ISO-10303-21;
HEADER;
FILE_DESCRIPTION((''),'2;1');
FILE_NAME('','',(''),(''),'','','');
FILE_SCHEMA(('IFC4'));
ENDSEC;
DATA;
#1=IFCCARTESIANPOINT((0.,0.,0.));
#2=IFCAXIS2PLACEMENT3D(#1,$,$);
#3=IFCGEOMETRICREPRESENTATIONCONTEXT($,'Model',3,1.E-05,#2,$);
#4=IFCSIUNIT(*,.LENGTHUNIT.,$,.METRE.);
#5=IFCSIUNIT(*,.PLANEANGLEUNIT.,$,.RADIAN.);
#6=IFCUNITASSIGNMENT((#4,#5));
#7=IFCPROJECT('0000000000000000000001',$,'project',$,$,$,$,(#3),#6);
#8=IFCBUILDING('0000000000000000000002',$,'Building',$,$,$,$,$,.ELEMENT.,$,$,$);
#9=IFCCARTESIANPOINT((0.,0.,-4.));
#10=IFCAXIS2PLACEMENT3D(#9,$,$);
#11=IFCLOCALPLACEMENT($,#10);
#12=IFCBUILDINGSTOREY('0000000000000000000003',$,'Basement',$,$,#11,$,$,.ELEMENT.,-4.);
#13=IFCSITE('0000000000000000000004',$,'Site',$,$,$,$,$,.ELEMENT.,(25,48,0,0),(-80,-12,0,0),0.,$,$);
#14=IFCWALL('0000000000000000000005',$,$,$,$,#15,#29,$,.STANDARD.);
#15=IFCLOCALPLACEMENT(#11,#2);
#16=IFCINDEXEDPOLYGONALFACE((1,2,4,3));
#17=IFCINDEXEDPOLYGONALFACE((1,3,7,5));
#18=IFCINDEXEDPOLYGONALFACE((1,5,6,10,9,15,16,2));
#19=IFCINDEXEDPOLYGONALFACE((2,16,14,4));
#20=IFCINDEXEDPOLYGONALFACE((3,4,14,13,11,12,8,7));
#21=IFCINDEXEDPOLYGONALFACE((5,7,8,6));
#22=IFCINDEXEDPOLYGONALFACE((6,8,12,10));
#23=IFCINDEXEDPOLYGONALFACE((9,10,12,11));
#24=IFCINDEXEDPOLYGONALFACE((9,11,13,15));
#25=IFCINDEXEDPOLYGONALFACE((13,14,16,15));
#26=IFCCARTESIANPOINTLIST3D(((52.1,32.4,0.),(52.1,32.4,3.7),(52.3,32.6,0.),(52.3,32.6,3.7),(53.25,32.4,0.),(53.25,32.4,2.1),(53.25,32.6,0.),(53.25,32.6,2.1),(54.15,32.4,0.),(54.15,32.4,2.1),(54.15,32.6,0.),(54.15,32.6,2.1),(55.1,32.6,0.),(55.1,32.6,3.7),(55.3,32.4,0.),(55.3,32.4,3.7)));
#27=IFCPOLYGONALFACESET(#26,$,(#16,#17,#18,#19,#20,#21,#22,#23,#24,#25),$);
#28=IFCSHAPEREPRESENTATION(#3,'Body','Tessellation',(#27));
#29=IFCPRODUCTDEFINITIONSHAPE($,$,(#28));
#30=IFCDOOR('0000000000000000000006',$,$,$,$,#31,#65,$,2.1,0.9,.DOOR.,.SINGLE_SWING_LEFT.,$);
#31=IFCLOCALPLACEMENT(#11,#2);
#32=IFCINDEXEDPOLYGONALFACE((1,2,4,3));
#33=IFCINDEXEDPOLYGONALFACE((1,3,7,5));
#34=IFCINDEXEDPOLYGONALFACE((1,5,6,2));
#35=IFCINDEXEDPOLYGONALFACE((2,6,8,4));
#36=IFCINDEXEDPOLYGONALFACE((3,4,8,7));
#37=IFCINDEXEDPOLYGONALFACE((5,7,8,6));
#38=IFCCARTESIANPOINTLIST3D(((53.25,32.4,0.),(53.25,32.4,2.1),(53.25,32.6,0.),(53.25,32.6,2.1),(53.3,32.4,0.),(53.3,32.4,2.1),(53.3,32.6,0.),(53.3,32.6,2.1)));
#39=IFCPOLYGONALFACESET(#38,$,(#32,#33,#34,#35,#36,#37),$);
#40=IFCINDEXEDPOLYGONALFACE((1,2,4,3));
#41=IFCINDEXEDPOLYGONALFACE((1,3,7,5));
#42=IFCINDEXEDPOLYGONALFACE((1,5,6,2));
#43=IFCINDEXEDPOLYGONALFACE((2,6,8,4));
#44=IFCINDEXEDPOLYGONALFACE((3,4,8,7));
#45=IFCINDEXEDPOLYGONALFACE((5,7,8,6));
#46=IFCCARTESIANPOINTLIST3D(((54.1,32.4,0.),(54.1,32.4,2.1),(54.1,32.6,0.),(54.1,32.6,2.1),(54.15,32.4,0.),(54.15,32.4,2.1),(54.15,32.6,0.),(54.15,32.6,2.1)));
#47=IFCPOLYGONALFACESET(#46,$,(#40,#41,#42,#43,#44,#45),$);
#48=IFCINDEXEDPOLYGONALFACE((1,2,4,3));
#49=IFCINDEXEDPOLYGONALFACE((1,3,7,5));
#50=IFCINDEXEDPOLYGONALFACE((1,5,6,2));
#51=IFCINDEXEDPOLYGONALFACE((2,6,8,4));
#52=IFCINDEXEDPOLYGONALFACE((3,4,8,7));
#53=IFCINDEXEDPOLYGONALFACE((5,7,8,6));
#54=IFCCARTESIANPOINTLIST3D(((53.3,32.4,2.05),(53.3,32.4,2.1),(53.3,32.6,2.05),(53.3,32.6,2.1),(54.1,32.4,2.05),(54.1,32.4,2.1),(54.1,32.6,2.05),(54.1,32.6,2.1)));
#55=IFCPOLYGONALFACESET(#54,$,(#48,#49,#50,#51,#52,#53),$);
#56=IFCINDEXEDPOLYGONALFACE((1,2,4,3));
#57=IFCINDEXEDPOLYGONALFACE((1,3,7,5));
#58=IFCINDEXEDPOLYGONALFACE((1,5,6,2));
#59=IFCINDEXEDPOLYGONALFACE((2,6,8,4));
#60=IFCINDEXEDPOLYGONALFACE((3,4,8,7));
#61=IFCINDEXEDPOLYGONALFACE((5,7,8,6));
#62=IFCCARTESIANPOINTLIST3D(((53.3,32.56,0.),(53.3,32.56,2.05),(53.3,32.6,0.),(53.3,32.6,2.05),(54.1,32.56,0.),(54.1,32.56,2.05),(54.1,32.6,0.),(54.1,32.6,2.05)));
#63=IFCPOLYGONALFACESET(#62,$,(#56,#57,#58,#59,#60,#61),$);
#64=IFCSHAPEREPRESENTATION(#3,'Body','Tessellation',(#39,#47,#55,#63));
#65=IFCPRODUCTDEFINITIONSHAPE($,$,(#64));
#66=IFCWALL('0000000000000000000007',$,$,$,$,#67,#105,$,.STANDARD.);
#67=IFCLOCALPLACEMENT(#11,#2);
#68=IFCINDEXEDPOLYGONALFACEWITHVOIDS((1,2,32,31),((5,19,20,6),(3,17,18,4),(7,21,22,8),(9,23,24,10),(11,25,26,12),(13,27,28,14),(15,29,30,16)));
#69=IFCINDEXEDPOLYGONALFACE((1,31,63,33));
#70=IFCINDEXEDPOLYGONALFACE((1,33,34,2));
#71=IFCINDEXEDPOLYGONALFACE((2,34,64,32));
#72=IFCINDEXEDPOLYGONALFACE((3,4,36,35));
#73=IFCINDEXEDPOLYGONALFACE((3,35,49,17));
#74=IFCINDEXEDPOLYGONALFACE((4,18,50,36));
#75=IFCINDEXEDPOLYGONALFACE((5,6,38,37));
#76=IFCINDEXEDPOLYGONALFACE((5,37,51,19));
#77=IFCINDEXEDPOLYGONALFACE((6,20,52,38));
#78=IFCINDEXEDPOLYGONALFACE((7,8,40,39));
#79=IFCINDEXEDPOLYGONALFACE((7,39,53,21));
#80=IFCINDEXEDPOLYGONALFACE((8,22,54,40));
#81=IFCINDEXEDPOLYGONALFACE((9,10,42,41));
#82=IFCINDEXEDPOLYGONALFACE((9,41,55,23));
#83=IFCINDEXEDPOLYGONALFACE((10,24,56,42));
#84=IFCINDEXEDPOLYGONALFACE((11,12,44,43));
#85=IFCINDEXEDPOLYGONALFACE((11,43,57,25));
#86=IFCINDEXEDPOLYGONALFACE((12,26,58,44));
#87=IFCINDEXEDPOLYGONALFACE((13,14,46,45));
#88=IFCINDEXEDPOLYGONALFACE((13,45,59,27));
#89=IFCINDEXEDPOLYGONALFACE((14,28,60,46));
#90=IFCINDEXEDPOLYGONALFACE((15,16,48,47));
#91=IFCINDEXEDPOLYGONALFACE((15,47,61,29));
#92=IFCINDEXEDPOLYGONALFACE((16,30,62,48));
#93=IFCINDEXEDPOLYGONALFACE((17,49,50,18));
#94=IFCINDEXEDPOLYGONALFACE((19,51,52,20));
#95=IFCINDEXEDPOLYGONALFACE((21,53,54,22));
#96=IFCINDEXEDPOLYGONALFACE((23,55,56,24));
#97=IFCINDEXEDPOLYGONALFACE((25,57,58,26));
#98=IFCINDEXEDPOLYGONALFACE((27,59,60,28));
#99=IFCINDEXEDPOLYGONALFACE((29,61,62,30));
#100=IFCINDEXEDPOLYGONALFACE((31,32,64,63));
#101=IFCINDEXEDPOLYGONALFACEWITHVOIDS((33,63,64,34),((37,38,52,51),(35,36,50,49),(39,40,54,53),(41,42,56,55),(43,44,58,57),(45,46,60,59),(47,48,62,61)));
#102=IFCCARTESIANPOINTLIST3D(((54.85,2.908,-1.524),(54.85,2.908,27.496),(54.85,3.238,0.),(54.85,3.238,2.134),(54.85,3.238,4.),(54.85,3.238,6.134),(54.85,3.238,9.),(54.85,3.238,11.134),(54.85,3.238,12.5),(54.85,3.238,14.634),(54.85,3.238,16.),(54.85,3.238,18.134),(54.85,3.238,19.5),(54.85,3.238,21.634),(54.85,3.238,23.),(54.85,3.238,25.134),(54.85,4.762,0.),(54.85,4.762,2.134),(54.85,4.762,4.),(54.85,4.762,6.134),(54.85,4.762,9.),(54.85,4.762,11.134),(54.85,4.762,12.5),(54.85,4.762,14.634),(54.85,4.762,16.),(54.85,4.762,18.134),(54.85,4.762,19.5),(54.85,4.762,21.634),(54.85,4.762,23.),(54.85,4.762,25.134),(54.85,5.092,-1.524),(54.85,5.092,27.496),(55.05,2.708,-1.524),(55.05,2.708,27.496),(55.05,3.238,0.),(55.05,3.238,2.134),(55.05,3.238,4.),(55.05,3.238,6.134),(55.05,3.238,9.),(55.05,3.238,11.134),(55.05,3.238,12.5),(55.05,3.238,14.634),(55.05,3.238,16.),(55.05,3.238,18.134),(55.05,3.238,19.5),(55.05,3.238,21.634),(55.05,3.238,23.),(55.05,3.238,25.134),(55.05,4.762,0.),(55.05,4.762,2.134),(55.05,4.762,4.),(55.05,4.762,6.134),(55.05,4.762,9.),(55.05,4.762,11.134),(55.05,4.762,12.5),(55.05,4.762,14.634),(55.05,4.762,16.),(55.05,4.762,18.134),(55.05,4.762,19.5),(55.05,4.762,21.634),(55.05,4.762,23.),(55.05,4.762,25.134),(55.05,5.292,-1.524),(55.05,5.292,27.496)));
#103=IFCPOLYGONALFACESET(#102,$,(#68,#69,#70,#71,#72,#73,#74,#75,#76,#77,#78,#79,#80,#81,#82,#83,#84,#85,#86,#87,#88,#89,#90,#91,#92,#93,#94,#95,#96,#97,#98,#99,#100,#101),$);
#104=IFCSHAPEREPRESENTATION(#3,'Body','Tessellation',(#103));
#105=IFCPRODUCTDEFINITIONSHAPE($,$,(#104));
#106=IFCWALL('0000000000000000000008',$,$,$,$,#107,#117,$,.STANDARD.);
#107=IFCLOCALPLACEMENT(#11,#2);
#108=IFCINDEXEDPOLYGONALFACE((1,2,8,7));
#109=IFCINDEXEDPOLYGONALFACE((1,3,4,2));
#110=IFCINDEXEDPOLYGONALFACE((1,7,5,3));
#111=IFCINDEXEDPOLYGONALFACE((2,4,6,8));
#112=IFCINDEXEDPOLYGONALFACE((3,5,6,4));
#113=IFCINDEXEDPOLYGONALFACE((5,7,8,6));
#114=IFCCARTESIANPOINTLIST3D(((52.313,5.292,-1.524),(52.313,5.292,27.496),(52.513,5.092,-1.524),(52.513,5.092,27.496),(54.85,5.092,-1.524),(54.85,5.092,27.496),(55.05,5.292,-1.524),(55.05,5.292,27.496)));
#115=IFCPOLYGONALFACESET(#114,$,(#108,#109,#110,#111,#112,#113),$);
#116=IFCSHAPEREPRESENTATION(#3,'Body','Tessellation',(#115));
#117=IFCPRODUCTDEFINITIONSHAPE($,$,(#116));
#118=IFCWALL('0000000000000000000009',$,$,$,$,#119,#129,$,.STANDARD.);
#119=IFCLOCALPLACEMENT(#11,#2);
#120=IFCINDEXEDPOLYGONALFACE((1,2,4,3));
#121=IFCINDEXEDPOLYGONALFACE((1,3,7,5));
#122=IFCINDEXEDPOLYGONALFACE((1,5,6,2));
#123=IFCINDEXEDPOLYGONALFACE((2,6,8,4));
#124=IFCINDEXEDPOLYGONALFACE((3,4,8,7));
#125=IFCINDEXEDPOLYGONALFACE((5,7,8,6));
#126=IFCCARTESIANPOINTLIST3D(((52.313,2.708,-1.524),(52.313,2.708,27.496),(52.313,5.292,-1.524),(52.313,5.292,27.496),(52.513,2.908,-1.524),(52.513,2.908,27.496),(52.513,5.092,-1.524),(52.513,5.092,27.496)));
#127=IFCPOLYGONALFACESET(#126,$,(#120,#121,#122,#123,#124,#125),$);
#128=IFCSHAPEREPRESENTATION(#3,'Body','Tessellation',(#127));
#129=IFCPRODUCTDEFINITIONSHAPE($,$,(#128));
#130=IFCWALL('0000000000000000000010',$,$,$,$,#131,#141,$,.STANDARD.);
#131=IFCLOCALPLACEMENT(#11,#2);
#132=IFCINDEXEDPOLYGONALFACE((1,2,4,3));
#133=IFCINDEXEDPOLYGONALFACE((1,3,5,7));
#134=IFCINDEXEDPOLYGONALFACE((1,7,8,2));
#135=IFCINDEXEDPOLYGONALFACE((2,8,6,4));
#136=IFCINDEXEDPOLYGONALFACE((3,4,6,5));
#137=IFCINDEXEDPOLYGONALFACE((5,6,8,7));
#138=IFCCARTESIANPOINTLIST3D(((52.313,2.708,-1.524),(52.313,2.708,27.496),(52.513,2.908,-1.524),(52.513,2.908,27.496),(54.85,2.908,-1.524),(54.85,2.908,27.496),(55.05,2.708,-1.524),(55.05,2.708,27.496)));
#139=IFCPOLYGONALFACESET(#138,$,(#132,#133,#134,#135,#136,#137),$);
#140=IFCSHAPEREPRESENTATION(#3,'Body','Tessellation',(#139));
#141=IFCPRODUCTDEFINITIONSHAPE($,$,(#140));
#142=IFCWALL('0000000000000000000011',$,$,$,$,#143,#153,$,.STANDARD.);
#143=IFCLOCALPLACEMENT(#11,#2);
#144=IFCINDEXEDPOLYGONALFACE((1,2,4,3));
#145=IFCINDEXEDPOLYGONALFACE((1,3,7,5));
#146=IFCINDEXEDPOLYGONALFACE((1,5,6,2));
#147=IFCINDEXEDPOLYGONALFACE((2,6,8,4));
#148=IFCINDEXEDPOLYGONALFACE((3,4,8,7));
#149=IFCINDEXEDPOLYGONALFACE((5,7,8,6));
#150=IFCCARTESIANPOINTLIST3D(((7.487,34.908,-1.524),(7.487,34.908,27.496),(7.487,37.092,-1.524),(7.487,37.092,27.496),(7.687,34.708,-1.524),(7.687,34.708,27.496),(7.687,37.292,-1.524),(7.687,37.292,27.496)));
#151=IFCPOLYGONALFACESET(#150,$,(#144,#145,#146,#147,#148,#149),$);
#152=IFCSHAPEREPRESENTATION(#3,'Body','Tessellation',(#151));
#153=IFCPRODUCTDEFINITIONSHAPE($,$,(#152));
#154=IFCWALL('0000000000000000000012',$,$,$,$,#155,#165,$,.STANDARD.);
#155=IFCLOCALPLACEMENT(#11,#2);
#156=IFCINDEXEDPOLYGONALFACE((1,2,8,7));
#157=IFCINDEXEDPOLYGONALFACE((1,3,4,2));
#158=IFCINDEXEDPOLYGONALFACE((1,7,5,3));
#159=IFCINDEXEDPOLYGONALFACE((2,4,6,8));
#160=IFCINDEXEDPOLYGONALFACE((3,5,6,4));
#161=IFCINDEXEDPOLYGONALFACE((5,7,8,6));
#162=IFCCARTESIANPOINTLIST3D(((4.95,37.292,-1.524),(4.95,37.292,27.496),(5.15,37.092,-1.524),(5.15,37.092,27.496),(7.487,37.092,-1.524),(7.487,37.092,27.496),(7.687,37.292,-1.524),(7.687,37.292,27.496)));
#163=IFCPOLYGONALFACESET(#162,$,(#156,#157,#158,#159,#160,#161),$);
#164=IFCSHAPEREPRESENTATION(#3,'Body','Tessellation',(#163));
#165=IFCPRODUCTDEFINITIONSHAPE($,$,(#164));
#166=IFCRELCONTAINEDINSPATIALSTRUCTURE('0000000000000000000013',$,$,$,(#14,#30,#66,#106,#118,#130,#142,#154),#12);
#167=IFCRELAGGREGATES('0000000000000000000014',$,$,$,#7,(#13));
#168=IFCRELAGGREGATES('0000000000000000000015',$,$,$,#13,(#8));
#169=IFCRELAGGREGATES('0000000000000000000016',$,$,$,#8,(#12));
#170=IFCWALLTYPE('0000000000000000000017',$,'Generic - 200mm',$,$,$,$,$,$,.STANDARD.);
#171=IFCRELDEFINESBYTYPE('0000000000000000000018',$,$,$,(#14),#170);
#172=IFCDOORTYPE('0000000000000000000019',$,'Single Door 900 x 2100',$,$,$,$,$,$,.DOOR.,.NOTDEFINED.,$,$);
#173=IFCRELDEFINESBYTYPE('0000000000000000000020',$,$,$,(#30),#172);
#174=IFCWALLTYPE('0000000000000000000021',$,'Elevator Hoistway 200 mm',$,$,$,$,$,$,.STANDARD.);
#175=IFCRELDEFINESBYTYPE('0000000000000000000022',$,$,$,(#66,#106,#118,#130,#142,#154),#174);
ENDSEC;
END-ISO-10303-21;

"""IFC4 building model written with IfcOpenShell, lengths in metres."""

from ifc_helpers import new_model, si_unit, frame, frame_2d, origin, origin_with_axes, origin_2d, place, context, project, spatial, polyline, rectangle, outline, extrude, type_object, element, fill, save


model = new_model("IFC4")

# Units and contexts
model_context = context("Model", 3, precision=1e-05, world=origin())
ifc_project = project(units=[si_unit("LENGTHUNIT", "METRE"), si_unit("PLANEANGLEUNIT", "RADIAN")], contexts=[model_context])

# Site, building, storey
site = spatial("IfcSite", under=ifc_project, Name="Site", CompositionType="ELEMENT", RefLatitude=(25, 48, 0, 0), RefLongitude=(-80, -12, 0, 0), RefElevation=0.0)
building = spatial("IfcBuilding", under=site, Name="Building", CompositionType="ELEMENT")
storey_placement = place(None, frame((0.0, 0.0, -4.0)))
storey = spatial("IfcBuildingStorey", under=building, at=storey_placement, Name="Basement", CompositionType="ELEMENT", Elevation=-4.0)

# Shared definitions
wall_type_1 = type_object("IfcWallType", Name="Generic - 200mm", PredefinedType="STANDARD")
door_type = type_object("IfcDoorType", Name="Single Door 900 x 2100", OperationType="NOTDEFINED", PredefinedType="DOOR")

# Wall, opening, door
wall_1_placement = place(None, frame((52.2, 32.5, -4.0), z_axis=(0.0, 0.0, 1.0), x_axis=(1.0, 0.0, 0.0)))
wall_1 = element("IfcWall", 1, at=wall_1_placement, inside=storey, type_object=wall_type_1, PredefinedType="STANDARD", context=model_context, shape_type="SweptSolid", body=[
    extrude(outline(polyline([(-0.1, -0.1), (3.1, -0.1), (2.9, 0.1), (0.1, 0.1), (-0.1, -0.1)])), origin(), (0.0, 0.0, 1.0), 3.7),
])
opening_1_placement = place(wall_1_placement, frame((1.5, 0.0, 0.0), z_axis=(0.0, 0.0, 1.0), x_axis=(1.0, 0.0, 0.0)))
opening_1 = element("IfcOpeningElement", 2, at=opening_1_placement, cuts=wall_1, PredefinedType="OPENING", context=model_context, shape_type="SweptSolid", body=[
    extrude(rectangle(XDim=0.9, YDim=0.202, at=origin_2d()), origin(), (0.0, 0.0, 1.0), 2.1),
])
door_1_placement = place(opening_1_placement, origin_with_axes())
door_1 = element("IfcDoor", 3, at=door_1_placement, inside=storey, type_object=door_type, OperationType="SINGLE_SWING_LEFT", OverallHeight=2.1, OverallWidth=0.9, PredefinedType="DOOR", context=model_context, shape_type="SweptSolid", body=[
    extrude(rectangle(XDim=0.05, YDim=0.2, at=frame_2d((-0.425, 0.0))), origin(), (0.0, 0.0, 1.0), 2.1),
    extrude(rectangle(XDim=0.05, YDim=0.2, at=frame_2d((0.425, 0.0))), origin(), (0.0, 0.0, 1.0), 2.1),
    extrude(rectangle(XDim=0.8, YDim=0.2, at=origin_2d()), frame((0.0, 0.0, 2.05)), (0.0, 0.0, 1.0), 0.05),
    extrude(rectangle(XDim=0.8, YDim=0.04, at=frame_2d((0.0, 0.08))), origin(), (0.0, 0.0, 1.0), 2.05),
])
fill(opening_1, door_1)

# Wall, openings
wall_type_2 = type_object("IfcWallType", Name="Elevator Hoistway 200 mm", PredefinedType="STANDARD")
wall_2_placement = place(None, frame((54.95, 2.808, -5.524), z_axis=(0.0, 0.0, 1.0), x_axis=(0.0, 1.0, 0.0)))
wall_2 = element("IfcWall", 4, at=wall_2_placement, inside=storey, type_object=wall_type_2, PredefinedType="STANDARD", context=model_context, shape_type="SweptSolid", body=[
    extrude(outline(polyline([(-0.1, -0.1), (2.484, -0.1), (2.284, 0.1), (0.1, 0.1), (-0.1, -0.1)])), origin(), (0.0, 0.0, 1.0), 29.02),
])
opening_2_placement = place(wall_2_placement, frame((1.192, 0.0, 1.524), z_axis=(0.0, 0.0, 1.0), x_axis=(1.0, 0.0, 0.0)))
element("IfcOpeningElement", 5, at=opening_2_placement, cuts=wall_2, PredefinedType="OPENING", context=model_context, shape_type="SweptSolid", body=[
    extrude(rectangle(XDim=1.524, YDim=0.202, at=origin_2d()), origin(), (0.0, 0.0, 1.0), 2.134),
])
opening_3_placement = place(wall_2_placement, frame((1.192, 0.0, 5.524), z_axis=(0.0, 0.0, 1.0), x_axis=(1.0, 0.0, 0.0)))
element("IfcOpeningElement", 6, at=opening_3_placement, cuts=wall_2, PredefinedType="OPENING", context=model_context, shape_type="SweptSolid", body=[
    extrude(rectangle(XDim=1.524, YDim=0.202, at=origin_2d()), origin(), (0.0, 0.0, 1.0), 2.134),
])
opening_4_placement = place(wall_2_placement, frame((1.192, 0.0, 10.524), z_axis=(0.0, 0.0, 1.0), x_axis=(1.0, 0.0, 0.0)))
element("IfcOpeningElement", 7, at=opening_4_placement, cuts=wall_2, PredefinedType="OPENING", context=model_context, shape_type="SweptSolid", body=[
    extrude(rectangle(XDim=1.524, YDim=0.202, at=origin_2d()), origin(), (0.0, 0.0, 1.0), 2.134),
])
opening_5_placement = place(wall_2_placement, frame((1.192, 0.0, 14.024), z_axis=(0.0, 0.0, 1.0), x_axis=(1.0, 0.0, 0.0)))
element("IfcOpeningElement", 8, at=opening_5_placement, cuts=wall_2, PredefinedType="OPENING", context=model_context, shape_type="SweptSolid", body=[
    extrude(rectangle(XDim=1.524, YDim=0.202, at=origin_2d()), origin(), (0.0, 0.0, 1.0), 2.134),
])
opening_6_placement = place(wall_2_placement, frame((1.192, 0.0, 17.524), z_axis=(0.0, 0.0, 1.0), x_axis=(1.0, 0.0, 0.0)))
element("IfcOpeningElement", 9, at=opening_6_placement, cuts=wall_2, PredefinedType="OPENING", context=model_context, shape_type="SweptSolid", body=[
    extrude(rectangle(XDim=1.524, YDim=0.202, at=origin_2d()), origin(), (0.0, 0.0, 1.0), 2.134),
])
opening_7_placement = place(wall_2_placement, frame((1.192, 0.0, 21.024), z_axis=(0.0, 0.0, 1.0), x_axis=(1.0, 0.0, 0.0)))
element("IfcOpeningElement", 10, at=opening_7_placement, cuts=wall_2, PredefinedType="OPENING", context=model_context, shape_type="SweptSolid", body=[
    extrude(rectangle(XDim=1.524, YDim=0.202, at=origin_2d()), origin(), (0.0, 0.0, 1.0), 2.134),
])
opening_8_placement = place(wall_2_placement, frame((1.192, 0.0, 24.524), z_axis=(0.0, 0.0, 1.0), x_axis=(1.0, 0.0, 0.0)))
element("IfcOpeningElement", 11, at=opening_8_placement, cuts=wall_2, PredefinedType="OPENING", context=model_context, shape_type="SweptSolid", body=[
    extrude(rectangle(XDim=1.524, YDim=0.202, at=origin_2d()), origin(), (0.0, 0.0, 1.0), 2.134),
])

# Walls
wall_3_placement = place(None, frame((54.95, 5.192, -5.524), z_axis=(0.0, 0.0, 1.0), x_axis=(-1.0, 0.0, 0.0)))
element("IfcWall", 12, at=wall_3_placement, inside=storey, type_object=wall_type_2, PredefinedType="STANDARD", context=model_context, shape_type="SweptSolid", body=[
    extrude(outline(polyline([(-0.1, -0.1), (2.637, -0.1), (2.437, 0.1), (0.1, 0.1), (-0.1, -0.1)])), origin(), (0.0, 0.0, 1.0), 29.02),
])
wall_4_placement = place(None, frame((52.413, 5.192, -5.524), z_axis=(0.0, 0.0, 1.0), x_axis=(0.0, -1.0, 0.0)))
element("IfcWall", 13, at=wall_4_placement, inside=storey, type_object=wall_type_2, PredefinedType="STANDARD", context=model_context, shape_type="SweptSolid", body=[
    extrude(outline(polyline([(-0.1, -0.1), (2.484, -0.1), (2.284, 0.1), (0.1, 0.1), (-0.1, -0.1)])), origin(), (0.0, 0.0, 1.0), 29.02),
])
wall_5_placement = place(None, frame((52.413, 2.808, -5.524), z_axis=(0.0, 0.0, 1.0), x_axis=(1.0, 0.0, 0.0)))
element("IfcWall", 14, at=wall_5_placement, inside=storey, type_object=wall_type_2, PredefinedType="STANDARD", context=model_context, shape_type="SweptSolid", body=[
    extrude(outline(polyline([(-0.1, -0.1), (2.637, -0.1), (2.437, 0.1), (0.1, 0.1), (-0.1, -0.1)])), origin(), (0.0, 0.0, 1.0), 29.02),
])
wall_6_placement = place(None, frame((7.587, 34.808, -5.524), z_axis=(0.0, 0.0, 1.0), x_axis=(0.0, 1.0, 0.0)))
element("IfcWall", 15, at=wall_6_placement, inside=storey, type_object=wall_type_2, PredefinedType="STANDARD", context=model_context, shape_type="SweptSolid", body=[
    extrude(outline(polyline([(-0.1, -0.1), (2.484, -0.1), (2.284, 0.1), (0.1, 0.1), (-0.1, -0.1)])), origin(), (0.0, 0.0, 1.0), 29.02),
])
wall_7_placement = place(None, frame((7.587, 37.192, -5.524), z_axis=(0.0, 0.0, 1.0), x_axis=(-1.0, 0.0, 0.0)))
element("IfcWall", 16, at=wall_7_placement, inside=storey, type_object=wall_type_2, PredefinedType="STANDARD", context=model_context, shape_type="SweptSolid", body=[
    extrude(outline(polyline([(-0.1, -0.1), (2.637, -0.1), (2.437, 0.1), (0.1, 0.1), (-0.1, -0.1)])), origin(), (0.0, 0.0, 1.0), 29.02),
])

save(model, "model.ifc")
